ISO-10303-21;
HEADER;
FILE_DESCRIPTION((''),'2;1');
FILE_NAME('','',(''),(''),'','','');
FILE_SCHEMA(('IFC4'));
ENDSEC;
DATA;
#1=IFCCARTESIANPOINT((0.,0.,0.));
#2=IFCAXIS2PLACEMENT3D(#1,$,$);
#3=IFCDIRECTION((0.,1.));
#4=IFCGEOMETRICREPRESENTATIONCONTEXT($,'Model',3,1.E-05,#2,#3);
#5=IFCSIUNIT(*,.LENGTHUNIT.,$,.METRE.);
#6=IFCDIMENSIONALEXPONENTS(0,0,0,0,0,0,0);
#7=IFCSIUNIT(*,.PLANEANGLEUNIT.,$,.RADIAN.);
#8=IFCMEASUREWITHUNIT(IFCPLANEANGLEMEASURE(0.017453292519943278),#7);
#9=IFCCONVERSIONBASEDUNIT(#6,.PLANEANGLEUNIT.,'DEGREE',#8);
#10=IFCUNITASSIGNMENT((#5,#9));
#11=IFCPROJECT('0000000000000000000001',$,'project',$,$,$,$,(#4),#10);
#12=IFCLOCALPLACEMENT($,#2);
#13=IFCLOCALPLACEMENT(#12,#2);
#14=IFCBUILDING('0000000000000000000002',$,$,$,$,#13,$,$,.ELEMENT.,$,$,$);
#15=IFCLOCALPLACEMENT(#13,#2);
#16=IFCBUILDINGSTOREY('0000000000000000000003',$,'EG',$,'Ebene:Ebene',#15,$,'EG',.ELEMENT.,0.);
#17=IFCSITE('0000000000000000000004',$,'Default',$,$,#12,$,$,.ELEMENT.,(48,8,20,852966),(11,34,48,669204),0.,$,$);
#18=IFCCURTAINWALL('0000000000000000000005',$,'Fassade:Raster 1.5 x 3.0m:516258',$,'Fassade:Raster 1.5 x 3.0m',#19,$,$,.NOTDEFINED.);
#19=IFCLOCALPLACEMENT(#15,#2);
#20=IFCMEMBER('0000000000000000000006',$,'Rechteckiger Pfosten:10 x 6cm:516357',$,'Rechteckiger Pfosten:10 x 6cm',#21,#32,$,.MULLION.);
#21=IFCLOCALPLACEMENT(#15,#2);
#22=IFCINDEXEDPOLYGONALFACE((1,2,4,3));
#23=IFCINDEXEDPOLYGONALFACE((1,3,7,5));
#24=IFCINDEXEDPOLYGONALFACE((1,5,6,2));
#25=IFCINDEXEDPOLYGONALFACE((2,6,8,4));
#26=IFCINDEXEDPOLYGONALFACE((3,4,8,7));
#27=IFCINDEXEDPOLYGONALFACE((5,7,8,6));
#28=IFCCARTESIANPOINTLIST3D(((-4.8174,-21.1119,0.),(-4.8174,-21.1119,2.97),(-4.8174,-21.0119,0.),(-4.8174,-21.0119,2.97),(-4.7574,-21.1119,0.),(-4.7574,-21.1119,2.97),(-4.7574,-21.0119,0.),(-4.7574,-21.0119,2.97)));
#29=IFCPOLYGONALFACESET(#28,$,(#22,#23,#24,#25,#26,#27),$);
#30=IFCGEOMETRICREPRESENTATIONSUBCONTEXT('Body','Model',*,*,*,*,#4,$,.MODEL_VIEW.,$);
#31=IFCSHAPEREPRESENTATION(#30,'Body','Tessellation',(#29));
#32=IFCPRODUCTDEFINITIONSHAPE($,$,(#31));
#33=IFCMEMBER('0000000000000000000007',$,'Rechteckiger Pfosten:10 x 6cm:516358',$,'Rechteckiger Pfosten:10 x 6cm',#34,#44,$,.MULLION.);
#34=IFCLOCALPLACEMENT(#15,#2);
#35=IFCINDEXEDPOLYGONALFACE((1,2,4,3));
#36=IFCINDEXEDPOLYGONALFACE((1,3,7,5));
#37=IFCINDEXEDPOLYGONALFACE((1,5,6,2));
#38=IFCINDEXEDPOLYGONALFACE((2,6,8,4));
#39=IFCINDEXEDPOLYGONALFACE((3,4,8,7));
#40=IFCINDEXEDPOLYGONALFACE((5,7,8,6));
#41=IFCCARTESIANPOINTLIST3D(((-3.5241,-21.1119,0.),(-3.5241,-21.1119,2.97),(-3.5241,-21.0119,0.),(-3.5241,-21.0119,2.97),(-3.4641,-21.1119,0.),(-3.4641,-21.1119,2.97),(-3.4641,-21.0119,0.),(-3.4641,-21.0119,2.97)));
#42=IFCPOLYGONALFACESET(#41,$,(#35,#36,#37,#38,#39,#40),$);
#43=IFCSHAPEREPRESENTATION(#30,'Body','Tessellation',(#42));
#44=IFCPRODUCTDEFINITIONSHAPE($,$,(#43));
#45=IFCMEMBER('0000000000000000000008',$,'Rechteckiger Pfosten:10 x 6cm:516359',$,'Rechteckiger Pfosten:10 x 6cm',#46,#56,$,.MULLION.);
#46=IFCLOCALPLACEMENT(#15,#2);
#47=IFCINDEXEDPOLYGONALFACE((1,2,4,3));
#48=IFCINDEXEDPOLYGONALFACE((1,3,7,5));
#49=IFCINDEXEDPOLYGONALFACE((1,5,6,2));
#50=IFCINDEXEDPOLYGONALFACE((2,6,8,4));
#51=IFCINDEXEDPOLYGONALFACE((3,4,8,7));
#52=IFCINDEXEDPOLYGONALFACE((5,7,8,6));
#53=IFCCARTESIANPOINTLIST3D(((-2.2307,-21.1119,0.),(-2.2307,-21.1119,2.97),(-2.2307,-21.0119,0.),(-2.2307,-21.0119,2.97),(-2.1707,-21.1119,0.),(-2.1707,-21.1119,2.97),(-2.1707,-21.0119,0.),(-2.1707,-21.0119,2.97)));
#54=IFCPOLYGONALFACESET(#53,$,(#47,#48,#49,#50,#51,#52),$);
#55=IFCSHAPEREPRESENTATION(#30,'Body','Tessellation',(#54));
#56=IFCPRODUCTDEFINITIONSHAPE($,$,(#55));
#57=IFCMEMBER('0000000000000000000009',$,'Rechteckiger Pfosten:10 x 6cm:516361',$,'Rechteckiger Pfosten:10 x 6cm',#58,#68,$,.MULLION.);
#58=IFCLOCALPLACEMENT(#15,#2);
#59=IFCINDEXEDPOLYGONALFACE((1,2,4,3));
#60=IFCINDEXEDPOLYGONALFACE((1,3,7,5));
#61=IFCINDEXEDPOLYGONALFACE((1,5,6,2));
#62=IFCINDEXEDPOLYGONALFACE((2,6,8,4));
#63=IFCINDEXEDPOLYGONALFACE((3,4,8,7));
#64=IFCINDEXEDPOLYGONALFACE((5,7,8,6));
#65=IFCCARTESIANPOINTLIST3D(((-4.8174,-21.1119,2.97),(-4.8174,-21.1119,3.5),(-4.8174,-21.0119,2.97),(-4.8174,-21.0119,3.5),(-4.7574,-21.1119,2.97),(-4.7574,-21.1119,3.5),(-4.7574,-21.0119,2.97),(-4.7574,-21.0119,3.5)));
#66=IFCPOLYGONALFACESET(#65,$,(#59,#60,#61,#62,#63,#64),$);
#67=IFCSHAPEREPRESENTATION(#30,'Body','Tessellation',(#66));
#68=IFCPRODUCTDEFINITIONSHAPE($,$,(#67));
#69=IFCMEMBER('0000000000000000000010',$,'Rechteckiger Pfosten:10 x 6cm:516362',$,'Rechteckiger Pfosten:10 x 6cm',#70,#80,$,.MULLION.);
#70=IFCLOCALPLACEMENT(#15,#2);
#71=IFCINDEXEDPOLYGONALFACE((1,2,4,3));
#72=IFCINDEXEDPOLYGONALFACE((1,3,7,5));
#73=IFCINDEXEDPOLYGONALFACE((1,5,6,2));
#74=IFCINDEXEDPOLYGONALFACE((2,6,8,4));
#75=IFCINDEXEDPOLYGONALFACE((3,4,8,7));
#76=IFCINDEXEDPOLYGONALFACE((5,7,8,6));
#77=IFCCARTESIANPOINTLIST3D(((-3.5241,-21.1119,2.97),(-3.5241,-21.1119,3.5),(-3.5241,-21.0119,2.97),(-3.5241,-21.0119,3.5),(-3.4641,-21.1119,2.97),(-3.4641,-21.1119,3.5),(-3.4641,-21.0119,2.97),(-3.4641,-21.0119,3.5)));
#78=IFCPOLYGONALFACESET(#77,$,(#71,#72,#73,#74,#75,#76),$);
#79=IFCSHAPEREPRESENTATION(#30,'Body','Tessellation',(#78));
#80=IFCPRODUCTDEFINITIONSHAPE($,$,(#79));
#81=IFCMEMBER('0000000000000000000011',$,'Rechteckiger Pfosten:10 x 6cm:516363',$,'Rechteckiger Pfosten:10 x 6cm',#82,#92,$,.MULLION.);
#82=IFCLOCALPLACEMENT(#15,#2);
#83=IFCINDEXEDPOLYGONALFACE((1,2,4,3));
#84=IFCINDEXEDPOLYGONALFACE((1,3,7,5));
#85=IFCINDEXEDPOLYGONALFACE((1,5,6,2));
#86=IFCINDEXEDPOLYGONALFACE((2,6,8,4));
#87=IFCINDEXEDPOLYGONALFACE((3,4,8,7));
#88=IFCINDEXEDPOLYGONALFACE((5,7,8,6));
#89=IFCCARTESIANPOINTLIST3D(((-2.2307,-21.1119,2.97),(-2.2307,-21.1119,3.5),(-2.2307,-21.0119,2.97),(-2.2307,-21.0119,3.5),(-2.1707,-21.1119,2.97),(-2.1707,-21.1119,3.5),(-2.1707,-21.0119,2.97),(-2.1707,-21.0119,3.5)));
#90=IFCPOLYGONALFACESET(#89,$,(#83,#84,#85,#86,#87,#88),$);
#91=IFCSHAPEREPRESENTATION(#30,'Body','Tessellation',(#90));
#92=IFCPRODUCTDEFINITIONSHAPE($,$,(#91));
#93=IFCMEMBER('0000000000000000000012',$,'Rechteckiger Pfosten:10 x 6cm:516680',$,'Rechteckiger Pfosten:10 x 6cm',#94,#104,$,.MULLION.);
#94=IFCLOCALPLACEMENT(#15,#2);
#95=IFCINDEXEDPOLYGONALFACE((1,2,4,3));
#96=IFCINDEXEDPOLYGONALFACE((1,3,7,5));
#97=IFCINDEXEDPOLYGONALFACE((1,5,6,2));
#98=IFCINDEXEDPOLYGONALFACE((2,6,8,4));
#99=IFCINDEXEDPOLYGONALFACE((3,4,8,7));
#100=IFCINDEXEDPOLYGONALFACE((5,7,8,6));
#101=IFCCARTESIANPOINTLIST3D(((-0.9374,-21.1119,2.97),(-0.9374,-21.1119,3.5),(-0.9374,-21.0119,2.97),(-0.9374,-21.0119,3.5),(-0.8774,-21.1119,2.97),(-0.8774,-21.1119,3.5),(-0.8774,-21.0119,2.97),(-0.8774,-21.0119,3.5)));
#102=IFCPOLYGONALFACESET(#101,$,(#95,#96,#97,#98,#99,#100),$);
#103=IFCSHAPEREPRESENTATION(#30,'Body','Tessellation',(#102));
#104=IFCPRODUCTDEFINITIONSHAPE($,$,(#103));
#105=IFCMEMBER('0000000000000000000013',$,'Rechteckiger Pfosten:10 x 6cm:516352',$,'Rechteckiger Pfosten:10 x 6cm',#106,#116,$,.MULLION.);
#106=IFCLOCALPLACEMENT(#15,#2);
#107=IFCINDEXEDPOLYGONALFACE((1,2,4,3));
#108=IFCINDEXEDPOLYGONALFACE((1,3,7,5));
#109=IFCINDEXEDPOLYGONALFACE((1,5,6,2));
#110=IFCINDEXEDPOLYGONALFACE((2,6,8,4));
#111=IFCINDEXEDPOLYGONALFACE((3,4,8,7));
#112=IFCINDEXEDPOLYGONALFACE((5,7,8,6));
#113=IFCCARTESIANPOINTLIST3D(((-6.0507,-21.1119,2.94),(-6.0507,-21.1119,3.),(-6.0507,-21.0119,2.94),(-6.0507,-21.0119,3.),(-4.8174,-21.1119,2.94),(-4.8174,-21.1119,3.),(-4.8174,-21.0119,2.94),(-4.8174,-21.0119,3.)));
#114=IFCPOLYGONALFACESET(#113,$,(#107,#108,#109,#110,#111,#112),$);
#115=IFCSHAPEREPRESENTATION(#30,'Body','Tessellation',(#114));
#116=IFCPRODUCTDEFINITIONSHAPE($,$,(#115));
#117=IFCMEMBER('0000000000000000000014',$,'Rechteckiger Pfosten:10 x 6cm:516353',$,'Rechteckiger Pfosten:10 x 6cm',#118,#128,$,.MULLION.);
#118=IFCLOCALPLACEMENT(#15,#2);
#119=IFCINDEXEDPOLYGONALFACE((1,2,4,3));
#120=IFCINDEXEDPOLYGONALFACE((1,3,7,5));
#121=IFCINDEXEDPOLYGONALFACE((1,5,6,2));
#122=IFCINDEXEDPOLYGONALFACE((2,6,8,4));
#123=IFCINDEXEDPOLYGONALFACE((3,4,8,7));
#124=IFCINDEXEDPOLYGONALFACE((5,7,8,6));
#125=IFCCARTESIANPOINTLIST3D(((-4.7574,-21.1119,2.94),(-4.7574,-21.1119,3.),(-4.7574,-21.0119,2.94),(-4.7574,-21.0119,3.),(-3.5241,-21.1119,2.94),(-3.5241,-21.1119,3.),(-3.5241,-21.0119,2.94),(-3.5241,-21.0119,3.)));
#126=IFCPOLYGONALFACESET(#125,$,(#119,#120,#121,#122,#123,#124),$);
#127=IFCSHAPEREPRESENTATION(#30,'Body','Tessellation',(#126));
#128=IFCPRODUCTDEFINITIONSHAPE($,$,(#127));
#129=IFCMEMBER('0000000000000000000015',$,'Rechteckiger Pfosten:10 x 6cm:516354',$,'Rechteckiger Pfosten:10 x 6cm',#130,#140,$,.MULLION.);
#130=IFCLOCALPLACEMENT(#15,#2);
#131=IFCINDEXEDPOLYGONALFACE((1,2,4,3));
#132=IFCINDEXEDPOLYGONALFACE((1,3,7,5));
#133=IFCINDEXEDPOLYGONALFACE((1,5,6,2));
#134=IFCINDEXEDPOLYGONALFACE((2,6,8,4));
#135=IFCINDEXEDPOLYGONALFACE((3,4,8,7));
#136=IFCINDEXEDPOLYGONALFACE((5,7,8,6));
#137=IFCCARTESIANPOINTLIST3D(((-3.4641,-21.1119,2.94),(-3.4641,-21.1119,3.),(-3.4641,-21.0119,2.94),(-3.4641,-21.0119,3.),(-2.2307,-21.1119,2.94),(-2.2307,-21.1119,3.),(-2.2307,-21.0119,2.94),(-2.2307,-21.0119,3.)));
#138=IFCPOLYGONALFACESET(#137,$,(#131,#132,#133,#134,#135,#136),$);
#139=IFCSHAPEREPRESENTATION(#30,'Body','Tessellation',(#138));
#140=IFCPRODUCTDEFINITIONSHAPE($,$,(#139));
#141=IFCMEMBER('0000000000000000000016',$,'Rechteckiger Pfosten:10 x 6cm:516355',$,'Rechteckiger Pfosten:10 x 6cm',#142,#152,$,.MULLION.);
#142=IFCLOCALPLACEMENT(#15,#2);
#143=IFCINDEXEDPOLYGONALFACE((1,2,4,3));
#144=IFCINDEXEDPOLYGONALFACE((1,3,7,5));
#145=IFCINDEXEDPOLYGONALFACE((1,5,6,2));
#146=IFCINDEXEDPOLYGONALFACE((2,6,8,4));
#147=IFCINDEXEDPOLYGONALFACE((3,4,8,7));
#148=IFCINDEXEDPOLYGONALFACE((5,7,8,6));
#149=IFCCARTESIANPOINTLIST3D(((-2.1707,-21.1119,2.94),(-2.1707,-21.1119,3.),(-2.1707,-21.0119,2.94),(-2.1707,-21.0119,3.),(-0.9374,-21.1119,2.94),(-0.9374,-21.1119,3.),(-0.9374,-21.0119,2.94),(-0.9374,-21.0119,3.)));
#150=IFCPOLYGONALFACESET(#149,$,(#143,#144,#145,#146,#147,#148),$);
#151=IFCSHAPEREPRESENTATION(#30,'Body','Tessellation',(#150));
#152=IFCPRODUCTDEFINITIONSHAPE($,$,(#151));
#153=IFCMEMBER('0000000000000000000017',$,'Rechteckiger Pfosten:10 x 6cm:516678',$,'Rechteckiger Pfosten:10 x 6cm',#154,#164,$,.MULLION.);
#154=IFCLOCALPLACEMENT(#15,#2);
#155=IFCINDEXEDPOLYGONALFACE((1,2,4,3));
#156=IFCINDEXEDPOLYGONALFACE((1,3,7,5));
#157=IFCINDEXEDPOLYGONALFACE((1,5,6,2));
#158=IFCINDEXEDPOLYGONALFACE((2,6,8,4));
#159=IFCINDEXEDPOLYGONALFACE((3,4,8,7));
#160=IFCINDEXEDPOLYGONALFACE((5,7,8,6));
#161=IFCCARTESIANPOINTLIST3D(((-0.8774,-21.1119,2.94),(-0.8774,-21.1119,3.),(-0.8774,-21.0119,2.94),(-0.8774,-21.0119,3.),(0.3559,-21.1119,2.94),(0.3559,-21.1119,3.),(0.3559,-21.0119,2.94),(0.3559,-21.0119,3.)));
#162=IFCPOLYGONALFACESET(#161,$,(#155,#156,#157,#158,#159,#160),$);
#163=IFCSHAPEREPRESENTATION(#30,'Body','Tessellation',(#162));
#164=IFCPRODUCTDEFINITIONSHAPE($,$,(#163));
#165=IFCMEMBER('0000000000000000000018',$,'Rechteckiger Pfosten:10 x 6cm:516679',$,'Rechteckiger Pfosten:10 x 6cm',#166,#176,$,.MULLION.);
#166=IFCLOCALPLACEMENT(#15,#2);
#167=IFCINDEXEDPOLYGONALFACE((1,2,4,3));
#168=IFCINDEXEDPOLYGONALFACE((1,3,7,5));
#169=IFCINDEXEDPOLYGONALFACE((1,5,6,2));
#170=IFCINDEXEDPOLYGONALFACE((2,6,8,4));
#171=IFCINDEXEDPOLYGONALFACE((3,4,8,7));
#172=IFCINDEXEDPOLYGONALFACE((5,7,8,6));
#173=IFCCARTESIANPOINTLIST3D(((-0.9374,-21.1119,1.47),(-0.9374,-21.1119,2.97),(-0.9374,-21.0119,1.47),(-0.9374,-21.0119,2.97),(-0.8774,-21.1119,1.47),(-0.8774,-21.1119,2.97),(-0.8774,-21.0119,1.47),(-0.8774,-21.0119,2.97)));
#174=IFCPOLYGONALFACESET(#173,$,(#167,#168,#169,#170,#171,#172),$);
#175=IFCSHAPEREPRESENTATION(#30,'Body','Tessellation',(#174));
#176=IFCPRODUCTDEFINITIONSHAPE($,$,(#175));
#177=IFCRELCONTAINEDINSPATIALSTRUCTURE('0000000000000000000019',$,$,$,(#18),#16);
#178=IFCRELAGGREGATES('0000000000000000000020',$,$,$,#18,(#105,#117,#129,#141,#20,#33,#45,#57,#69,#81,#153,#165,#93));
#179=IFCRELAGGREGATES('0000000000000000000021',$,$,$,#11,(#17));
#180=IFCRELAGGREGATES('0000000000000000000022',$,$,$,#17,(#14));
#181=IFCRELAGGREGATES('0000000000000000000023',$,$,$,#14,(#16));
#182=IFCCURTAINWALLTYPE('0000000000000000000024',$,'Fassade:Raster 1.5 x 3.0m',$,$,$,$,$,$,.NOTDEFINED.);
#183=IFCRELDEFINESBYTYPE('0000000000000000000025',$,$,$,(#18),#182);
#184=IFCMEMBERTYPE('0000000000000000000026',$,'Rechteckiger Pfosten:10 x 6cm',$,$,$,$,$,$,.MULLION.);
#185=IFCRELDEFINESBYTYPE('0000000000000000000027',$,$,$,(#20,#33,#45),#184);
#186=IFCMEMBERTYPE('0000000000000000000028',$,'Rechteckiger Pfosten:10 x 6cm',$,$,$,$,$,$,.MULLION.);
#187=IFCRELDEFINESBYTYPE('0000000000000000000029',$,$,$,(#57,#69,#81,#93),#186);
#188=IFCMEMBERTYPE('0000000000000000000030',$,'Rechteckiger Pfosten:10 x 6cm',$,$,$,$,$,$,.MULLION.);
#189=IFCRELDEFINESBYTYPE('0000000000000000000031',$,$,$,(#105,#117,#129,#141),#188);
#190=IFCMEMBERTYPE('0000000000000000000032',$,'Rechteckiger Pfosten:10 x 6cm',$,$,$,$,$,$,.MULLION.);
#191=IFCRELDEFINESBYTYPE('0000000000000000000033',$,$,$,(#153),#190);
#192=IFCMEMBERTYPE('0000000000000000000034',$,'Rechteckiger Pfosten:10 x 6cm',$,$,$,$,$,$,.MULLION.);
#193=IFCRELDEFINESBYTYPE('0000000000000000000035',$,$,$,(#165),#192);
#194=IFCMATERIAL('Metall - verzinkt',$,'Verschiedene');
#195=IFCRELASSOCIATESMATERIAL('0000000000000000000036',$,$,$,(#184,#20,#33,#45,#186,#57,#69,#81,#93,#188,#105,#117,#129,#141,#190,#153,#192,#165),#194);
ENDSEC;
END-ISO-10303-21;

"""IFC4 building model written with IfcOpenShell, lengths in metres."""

from ifc_helpers import new_model, entity, si_unit, converted_unit, direction, frame, origin, place, context, subcontext, project, spatial, indexed_curve, outline, extrude, source, transform, mapped, material, type_object, type_shapes, element, aggregate, save


model = new_model("IFC4")

# Units and contexts
model_context = context("Model", 3, precision=1e-05, world=origin(), true_north=direction((0.0, 1.0)))
body_context = subcontext(model_context, "Body", "Model", "MODEL_VIEW")
ifc_project = project(units=[si_unit("LENGTHUNIT", "METRE"), converted_unit("PLANEANGLEUNIT", "DEGREE", entity("IfcPlaneAngleMeasure", 0.017453292519943278), si_unit("PLANEANGLEUNIT", "RADIAN"), dimensions=[0, 0, 0, 0, 0, 0, 0])], contexts=[model_context])

# Site, building, storey
site_placement = place(None, origin())
site = spatial("IfcSite", under=ifc_project, at=site_placement, Name="Default", CompositionType="ELEMENT", RefLatitude=(48, 8, 20, 852966), RefLongitude=(11, 34, 48, 669204), RefElevation=0.0)
building_placement = place(site_placement, origin())
building = spatial("IfcBuilding", under=site, at=building_placement, CompositionType="ELEMENT")
storey_placement = place(building_placement, origin())
storey = spatial("IfcBuildingStorey", under=building, at=storey_placement, Name="EG", ObjectType="Ebene:Ebene", LongName="EG", CompositionType="ELEMENT", Elevation=0.0)

# Curtain wall, members
curtain_wall_type = type_object("IfcCurtainWallType", Name="Fassade:Raster 1.5 x 3.0m", PredefinedType="NOTDEFINED")
curtain_wall_placement = place(storey_placement, origin())
curtain_wall = element("IfcCurtainWall", 1, at=curtain_wall_placement, inside=storey, type_object=curtain_wall_type, Name="Fassade:Raster 1.5 x 3.0m:516258", ObjectType="Fassade:Raster 1.5 x 3.0m", PredefinedType="NOTDEFINED")
ifc_material_1 = material(Name="Metall - verzinkt", Category="Verschiedene")
member_type_1 = type_object("IfcMemberType", Name="Rechteckiger Pfosten:10 x 6cm", PredefinedType="MULLION", material=ifc_material_1)
shared_shape_1 = source(origin(), body_context, "Body", "SweptSolid", [
    extrude(outline(indexed_curve([(-0.03, -0.05), (0.03, -0.05), (0.03, 0.05), (-0.03, 0.05), (-0.03, -0.05)], self_intersect=False)), frame((0.0, 0.0, -2.97), z_axis=(0.0, 0.0, 1.0), x_axis=(-1.0, 0.0, 0.0)), (0.0, 0.0, 1.0), 2.97),
])
type_shapes(member_type_1, [shared_shape_1])
member_1_placement = place(curtain_wall_placement, frame((-4.7874, -21.0619, 0.0), z_axis=(0.0, 0.0, -1.0), x_axis=(1.0, 0.0, 0.0)))
member_1 = element("IfcMember", 2, at=member_1_placement, type_object=member_type_1, material=ifc_material_1, Name="Rechteckiger Pfosten:10 x 6cm:516357", ObjectType="Rechteckiger Pfosten:10 x 6cm", PredefinedType="MULLION", context=body_context, shape_type="MappedRepresentation", body=[
    mapped(shared_shape_1, transform((0.0, 0.0, 0.0), scale=1.0)),
])
member_2_placement = place(curtain_wall_placement, frame((-3.4941, -21.0619, 0.0), z_axis=(0.0, 0.0, -1.0), x_axis=(1.0, 0.0, 0.0)))
member_2 = element("IfcMember", 3, at=member_2_placement, type_object=member_type_1, material=ifc_material_1, Name="Rechteckiger Pfosten:10 x 6cm:516358", ObjectType="Rechteckiger Pfosten:10 x 6cm", PredefinedType="MULLION", context=body_context, shape_type="MappedRepresentation", body=[
    mapped(shared_shape_1, transform((0.0, 0.0, 0.0), scale=1.0)),
])
member_3_placement = place(curtain_wall_placement, frame((-2.2007, -21.0619, 0.0), z_axis=(0.0, 0.0, -1.0), x_axis=(1.0, 0.0, 0.0)))
member_3 = element("IfcMember", 4, at=member_3_placement, type_object=member_type_1, material=ifc_material_1, Name="Rechteckiger Pfosten:10 x 6cm:516359", ObjectType="Rechteckiger Pfosten:10 x 6cm", PredefinedType="MULLION", context=body_context, shape_type="MappedRepresentation", body=[
    mapped(shared_shape_1, transform((0.0, 0.0, 0.0), scale=1.0)),
])
member_type_2 = type_object("IfcMemberType", Name="Rechteckiger Pfosten:10 x 6cm", PredefinedType="MULLION", material=ifc_material_1)
shared_shape_2 = source(origin(), body_context, "Body", "SweptSolid", [
    extrude(outline(indexed_curve([(-0.03, -0.05), (0.03, -0.05), (0.03, 0.05), (-0.03, 0.05), (-0.03, -0.05)], self_intersect=False)), frame((0.0, 0.0, -0.53), z_axis=(0.0, 0.0, 1.0), x_axis=(-1.0, 0.0, 0.0)), (0.0, 0.0, 1.0), 0.53),
])
type_shapes(member_type_2, [shared_shape_2])
member_4_placement = place(curtain_wall_placement, frame((-4.7874, -21.0619, 2.97), z_axis=(0.0, 0.0, -1.0), x_axis=(1.0, 0.0, 0.0)))
member_4 = element("IfcMember", 5, at=member_4_placement, type_object=member_type_2, material=ifc_material_1, Name="Rechteckiger Pfosten:10 x 6cm:516361", ObjectType="Rechteckiger Pfosten:10 x 6cm", PredefinedType="MULLION", context=body_context, shape_type="MappedRepresentation", body=[
    mapped(shared_shape_2, transform((0.0, 0.0, 0.0), scale=1.0)),
])
member_5_placement = place(curtain_wall_placement, frame((-3.4941, -21.0619, 2.97), z_axis=(0.0, 0.0, -1.0), x_axis=(1.0, 0.0, 0.0)))
member_5 = element("IfcMember", 6, at=member_5_placement, type_object=member_type_2, material=ifc_material_1, Name="Rechteckiger Pfosten:10 x 6cm:516362", ObjectType="Rechteckiger Pfosten:10 x 6cm", PredefinedType="MULLION", context=body_context, shape_type="MappedRepresentation", body=[
    mapped(shared_shape_2, transform((0.0, 0.0, 0.0), scale=1.0)),
])
member_6_placement = place(curtain_wall_placement, frame((-2.2007, -21.0619, 2.97), z_axis=(0.0, 0.0, -1.0), x_axis=(1.0, 0.0, 0.0)))
member_6 = element("IfcMember", 7, at=member_6_placement, type_object=member_type_2, material=ifc_material_1, Name="Rechteckiger Pfosten:10 x 6cm:516363", ObjectType="Rechteckiger Pfosten:10 x 6cm", PredefinedType="MULLION", context=body_context, shape_type="MappedRepresentation", body=[
    mapped(shared_shape_2, transform((0.0, 0.0, 0.0), scale=1.0)),
])
member_7_placement = place(curtain_wall_placement, frame((-0.9074, -21.0619, 2.97), z_axis=(0.0, 0.0, -1.0), x_axis=(1.0, 0.0, 0.0)))
member_7 = element("IfcMember", 8, at=member_7_placement, type_object=member_type_2, material=ifc_material_1, Name="Rechteckiger Pfosten:10 x 6cm:516680", ObjectType="Rechteckiger Pfosten:10 x 6cm", PredefinedType="MULLION", context=body_context, shape_type="MappedRepresentation", body=[
    mapped(shared_shape_2, transform((0.0, 0.0, 0.0), scale=1.0)),
])
member_type_3 = type_object("IfcMemberType", Name="Rechteckiger Pfosten:10 x 6cm", PredefinedType="MULLION", material=ifc_material_1)
shared_shape_3 = source(origin(), body_context, "Body", "SweptSolid", [
    extrude(outline(indexed_curve([(-0.03, -0.05), (0.03, -0.05), (0.03, 0.05), (-0.03, 0.05), (-0.03, -0.05)], self_intersect=False)), frame((0.0, 0.0, -1.2333), z_axis=(0.0, 0.0, 1.0), x_axis=(-1.0, 0.0, 0.0)), (0.0, 0.0, 1.0), 1.2333),
])
type_shapes(member_type_3, [shared_shape_3])
member_8_placement = place(curtain_wall_placement, frame((-4.8174, -21.0619, 2.97), z_axis=(1.0, 0.0, 0.0), x_axis=(0.0, 0.0, 1.0)))
member_8 = element("IfcMember", 9, at=member_8_placement, type_object=member_type_3, material=ifc_material_1, Name="Rechteckiger Pfosten:10 x 6cm:516352", ObjectType="Rechteckiger Pfosten:10 x 6cm", PredefinedType="MULLION", context=body_context, shape_type="MappedRepresentation", body=[
    mapped(shared_shape_3, transform((0.0, 0.0, 0.0), scale=1.0)),
])
member_9_placement = place(curtain_wall_placement, frame((-3.5241, -21.0619, 2.97), z_axis=(1.0, 0.0, 0.0), x_axis=(0.0, 0.0, 1.0)))
member_9 = element("IfcMember", 10, at=member_9_placement, type_object=member_type_3, material=ifc_material_1, Name="Rechteckiger Pfosten:10 x 6cm:516353", ObjectType="Rechteckiger Pfosten:10 x 6cm", PredefinedType="MULLION", context=body_context, shape_type="MappedRepresentation", body=[
    mapped(shared_shape_3, transform((0.0, 0.0, 0.0), scale=1.0)),
])
member_10_placement = place(curtain_wall_placement, frame((-2.2307, -21.0619, 2.97), z_axis=(1.0, 0.0, 0.0), x_axis=(0.0, 0.0, 1.0)))
member_10 = element("IfcMember", 11, at=member_10_placement, type_object=member_type_3, material=ifc_material_1, Name="Rechteckiger Pfosten:10 x 6cm:516354", ObjectType="Rechteckiger Pfosten:10 x 6cm", PredefinedType="MULLION", context=body_context, shape_type="MappedRepresentation", body=[
    mapped(shared_shape_3, transform((0.0, 0.0, 0.0), scale=1.0)),
])
member_11_placement = place(curtain_wall_placement, frame((-0.9374, -21.0619, 2.97), z_axis=(1.0, 0.0, 0.0), x_axis=(0.0, 0.0, 1.0)))
member_11 = element("IfcMember", 12, at=member_11_placement, type_object=member_type_3, material=ifc_material_1, Name="Rechteckiger Pfosten:10 x 6cm:516355", ObjectType="Rechteckiger Pfosten:10 x 6cm", PredefinedType="MULLION", context=body_context, shape_type="MappedRepresentation", body=[
    mapped(shared_shape_3, transform((0.0, 0.0, 0.0), scale=1.0)),
])
member_type_4 = type_object("IfcMemberType", Name="Rechteckiger Pfosten:10 x 6cm", PredefinedType="MULLION", material=ifc_material_1)
shared_shape_4 = source(origin(), body_context, "Body", "SweptSolid", [
    extrude(outline(indexed_curve([(-0.03, -0.05), (0.03, -0.05), (0.03, 0.05), (-0.03, 0.05), (-0.03, -0.05)], self_intersect=False)), frame((0.0, 0.0, -1.2333), z_axis=(0.0, 0.0, 1.0), x_axis=(-1.0, 0.0, 0.0)), (0.0, 0.0, 1.0), 1.2333),
])
type_shapes(member_type_4, [shared_shape_4])
member_12_placement = place(curtain_wall_placement, frame((0.3559, -21.0619, 2.97), z_axis=(1.0, 0.0, 0.0), x_axis=(0.0, 0.0, 1.0)))
member_12 = element("IfcMember", 13, at=member_12_placement, type_object=member_type_4, material=ifc_material_1, Name="Rechteckiger Pfosten:10 x 6cm:516678", ObjectType="Rechteckiger Pfosten:10 x 6cm", PredefinedType="MULLION", context=body_context, shape_type="MappedRepresentation", body=[
    mapped(shared_shape_4, transform((0.0, 0.0, 0.0), scale=1.0)),
])
member_type_5 = type_object("IfcMemberType", Name="Rechteckiger Pfosten:10 x 6cm", PredefinedType="MULLION", material=ifc_material_1)
shared_shape_5 = source(origin(), body_context, "Body", "SweptSolid", [
    extrude(outline(indexed_curve([(-0.03, -0.05), (0.03, -0.05), (0.03, 0.05), (-0.03, 0.05), (-0.03, -0.05)], self_intersect=False)), frame((0.0, 0.0, -1.5), z_axis=(0.0, 0.0, 1.0), x_axis=(-1.0, 0.0, 0.0)), (0.0, 0.0, 1.0), 1.5),
])
type_shapes(member_type_5, [shared_shape_5])
member_13_placement = place(curtain_wall_placement, frame((-0.9074, -21.0619, 1.47), z_axis=(0.0, 0.0, -1.0), x_axis=(1.0, 0.0, 0.0)))
member_13 = element("IfcMember", 14, at=member_13_placement, type_object=member_type_5, material=ifc_material_1, Name="Rechteckiger Pfosten:10 x 6cm:516679", ObjectType="Rechteckiger Pfosten:10 x 6cm", PredefinedType="MULLION", context=body_context, shape_type="MappedRepresentation", body=[
    mapped(shared_shape_5, transform((0.0, 0.0, 0.0), scale=1.0)),
])
aggregate(curtain_wall, [member_8, member_9, member_10, member_11, member_1, member_2, member_3, member_4, member_5, member_6, member_12, member_13, member_7])

save(model, "model.ifc")
